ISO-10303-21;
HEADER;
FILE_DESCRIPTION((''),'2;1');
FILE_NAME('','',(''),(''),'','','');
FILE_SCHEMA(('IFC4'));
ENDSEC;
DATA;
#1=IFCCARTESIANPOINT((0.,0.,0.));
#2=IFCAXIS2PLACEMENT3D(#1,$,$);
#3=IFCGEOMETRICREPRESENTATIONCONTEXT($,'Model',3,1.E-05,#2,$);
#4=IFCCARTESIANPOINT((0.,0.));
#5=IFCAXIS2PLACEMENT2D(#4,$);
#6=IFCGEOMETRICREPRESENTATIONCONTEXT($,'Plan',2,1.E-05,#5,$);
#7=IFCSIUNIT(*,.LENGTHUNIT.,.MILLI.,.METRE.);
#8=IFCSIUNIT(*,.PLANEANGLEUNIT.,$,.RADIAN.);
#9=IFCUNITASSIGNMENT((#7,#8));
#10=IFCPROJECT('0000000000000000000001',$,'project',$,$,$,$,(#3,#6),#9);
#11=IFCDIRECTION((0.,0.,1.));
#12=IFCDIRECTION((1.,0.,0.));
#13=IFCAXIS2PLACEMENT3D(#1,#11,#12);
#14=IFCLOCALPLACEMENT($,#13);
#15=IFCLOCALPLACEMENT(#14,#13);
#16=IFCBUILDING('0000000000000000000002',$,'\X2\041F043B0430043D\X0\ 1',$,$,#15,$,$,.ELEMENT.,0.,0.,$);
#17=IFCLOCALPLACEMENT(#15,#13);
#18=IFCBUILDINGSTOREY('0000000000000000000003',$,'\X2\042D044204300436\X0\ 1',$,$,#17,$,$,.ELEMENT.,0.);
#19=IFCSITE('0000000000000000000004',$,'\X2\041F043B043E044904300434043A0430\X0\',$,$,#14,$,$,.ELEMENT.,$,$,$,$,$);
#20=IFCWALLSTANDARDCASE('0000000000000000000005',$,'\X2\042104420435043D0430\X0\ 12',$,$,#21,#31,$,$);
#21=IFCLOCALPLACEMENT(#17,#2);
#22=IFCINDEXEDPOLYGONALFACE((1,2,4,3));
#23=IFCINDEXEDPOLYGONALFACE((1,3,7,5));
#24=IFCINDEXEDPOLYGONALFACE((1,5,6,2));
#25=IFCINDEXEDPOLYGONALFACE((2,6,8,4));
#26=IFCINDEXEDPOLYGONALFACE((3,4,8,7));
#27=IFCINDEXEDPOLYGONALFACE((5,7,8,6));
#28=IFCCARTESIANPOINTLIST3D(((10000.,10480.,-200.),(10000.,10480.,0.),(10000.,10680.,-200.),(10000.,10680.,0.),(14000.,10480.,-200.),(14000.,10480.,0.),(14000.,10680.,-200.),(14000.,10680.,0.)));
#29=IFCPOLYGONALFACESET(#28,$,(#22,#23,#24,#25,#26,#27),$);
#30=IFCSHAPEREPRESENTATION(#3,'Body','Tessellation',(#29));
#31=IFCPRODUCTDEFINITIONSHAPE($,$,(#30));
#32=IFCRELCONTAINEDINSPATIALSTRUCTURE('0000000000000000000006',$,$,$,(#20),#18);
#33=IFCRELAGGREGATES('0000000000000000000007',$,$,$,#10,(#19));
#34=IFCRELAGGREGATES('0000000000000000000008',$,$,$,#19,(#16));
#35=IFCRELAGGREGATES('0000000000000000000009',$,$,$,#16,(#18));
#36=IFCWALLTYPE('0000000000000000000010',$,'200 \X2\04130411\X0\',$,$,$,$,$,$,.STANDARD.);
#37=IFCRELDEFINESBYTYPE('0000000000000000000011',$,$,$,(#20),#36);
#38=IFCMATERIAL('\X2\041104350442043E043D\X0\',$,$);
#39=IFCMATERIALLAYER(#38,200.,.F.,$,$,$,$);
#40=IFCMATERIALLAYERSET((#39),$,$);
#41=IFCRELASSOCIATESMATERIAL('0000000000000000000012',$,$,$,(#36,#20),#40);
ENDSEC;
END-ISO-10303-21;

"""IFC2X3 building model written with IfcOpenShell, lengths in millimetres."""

from ifc_helpers import new_model, si_unit, frame, origin, origin_with_axes, origin_2d, place, context, project, spatial, polyline, segment, composite_curve, outline, extrude, material, layer, layer_set, layer_usage, type_object, element, save


model = new_model("IFC2X3")

# Units and contexts
model_context = context("Model", 3, precision=1e-05, world=origin())
plan_context = context("Plan", 2, precision=1e-05, world=origin_2d())
ifc_project = project(units=[si_unit("LENGTHUNIT", "METRE", prefix="MILLI"), si_unit("PLANEANGLEUNIT", "RADIAN")], contexts=[model_context, plan_context])

# Site, building, storey
site_placement = place(None, origin_with_axes())
site = spatial("IfcSite", under=ifc_project, at=site_placement, Name="Площадка", CompositionType="ELEMENT")
building_placement = place(site_placement, origin_with_axes())
building = spatial("IfcBuilding", under=site, at=building_placement, Name="План 1", CompositionType="ELEMENT", ElevationOfRefHeight=0.0, ElevationOfTerrain=0.0)
storey_placement = place(building_placement, origin_with_axes())
storey = spatial("IfcBuildingStorey", under=building, at=storey_placement, Name="Этаж 1", CompositionType="ELEMENT", Elevation=0.0)

# Wall
ifc_material = material(Name="Бетон")
ifc_layer_1 = layer(ifc_material, 200.0, ventilated=False)
ifc_layer_set_1 = layer_set([ifc_layer_1])
wall_type_1 = type_object("IfcWallType", Name="200 ГБ", PredefinedType="STANDARD", material=ifc_layer_set_1)
ifc_layer_usage_1 = layer_usage(ifc_layer_set_1, "AXIS2", "POSITIVE", 0.0)
wall_1_placement = place(storey_placement, frame((14000.0, 10680.0, -200.0), z_axis=(0.0, 0.0, 1.0), x_axis=(-1.0, 0.0, 0.0)))
element("IfcWallStandardCase", 1, at=wall_1_placement, inside=storey, type_object=wall_type_1, material=ifc_layer_usage_1, Name="Стена 12", context=model_context, shape_type="SweptSolid", body=[
    extrude(outline(composite_curve([segment(polyline([(0.0, 200.0), (0.0, 0.0)]), True, "CONTINUOUS"), segment(polyline([(0.0, 0.0), (4000.0, 0.0)]), True, "CONTINUOUS"), segment(polyline([(4000.0, 0.0), (4000.0, 200.0)]), True, "CONTINUOUS"), segment(polyline([(4000.0, 200.0), (0.0, 200.0)]), True, "CONTINUOUS")], self_intersect=False)), origin_with_axes(), (0.0, 0.0, 1.0), 200.0),
])

save(model, "model.ifc")
